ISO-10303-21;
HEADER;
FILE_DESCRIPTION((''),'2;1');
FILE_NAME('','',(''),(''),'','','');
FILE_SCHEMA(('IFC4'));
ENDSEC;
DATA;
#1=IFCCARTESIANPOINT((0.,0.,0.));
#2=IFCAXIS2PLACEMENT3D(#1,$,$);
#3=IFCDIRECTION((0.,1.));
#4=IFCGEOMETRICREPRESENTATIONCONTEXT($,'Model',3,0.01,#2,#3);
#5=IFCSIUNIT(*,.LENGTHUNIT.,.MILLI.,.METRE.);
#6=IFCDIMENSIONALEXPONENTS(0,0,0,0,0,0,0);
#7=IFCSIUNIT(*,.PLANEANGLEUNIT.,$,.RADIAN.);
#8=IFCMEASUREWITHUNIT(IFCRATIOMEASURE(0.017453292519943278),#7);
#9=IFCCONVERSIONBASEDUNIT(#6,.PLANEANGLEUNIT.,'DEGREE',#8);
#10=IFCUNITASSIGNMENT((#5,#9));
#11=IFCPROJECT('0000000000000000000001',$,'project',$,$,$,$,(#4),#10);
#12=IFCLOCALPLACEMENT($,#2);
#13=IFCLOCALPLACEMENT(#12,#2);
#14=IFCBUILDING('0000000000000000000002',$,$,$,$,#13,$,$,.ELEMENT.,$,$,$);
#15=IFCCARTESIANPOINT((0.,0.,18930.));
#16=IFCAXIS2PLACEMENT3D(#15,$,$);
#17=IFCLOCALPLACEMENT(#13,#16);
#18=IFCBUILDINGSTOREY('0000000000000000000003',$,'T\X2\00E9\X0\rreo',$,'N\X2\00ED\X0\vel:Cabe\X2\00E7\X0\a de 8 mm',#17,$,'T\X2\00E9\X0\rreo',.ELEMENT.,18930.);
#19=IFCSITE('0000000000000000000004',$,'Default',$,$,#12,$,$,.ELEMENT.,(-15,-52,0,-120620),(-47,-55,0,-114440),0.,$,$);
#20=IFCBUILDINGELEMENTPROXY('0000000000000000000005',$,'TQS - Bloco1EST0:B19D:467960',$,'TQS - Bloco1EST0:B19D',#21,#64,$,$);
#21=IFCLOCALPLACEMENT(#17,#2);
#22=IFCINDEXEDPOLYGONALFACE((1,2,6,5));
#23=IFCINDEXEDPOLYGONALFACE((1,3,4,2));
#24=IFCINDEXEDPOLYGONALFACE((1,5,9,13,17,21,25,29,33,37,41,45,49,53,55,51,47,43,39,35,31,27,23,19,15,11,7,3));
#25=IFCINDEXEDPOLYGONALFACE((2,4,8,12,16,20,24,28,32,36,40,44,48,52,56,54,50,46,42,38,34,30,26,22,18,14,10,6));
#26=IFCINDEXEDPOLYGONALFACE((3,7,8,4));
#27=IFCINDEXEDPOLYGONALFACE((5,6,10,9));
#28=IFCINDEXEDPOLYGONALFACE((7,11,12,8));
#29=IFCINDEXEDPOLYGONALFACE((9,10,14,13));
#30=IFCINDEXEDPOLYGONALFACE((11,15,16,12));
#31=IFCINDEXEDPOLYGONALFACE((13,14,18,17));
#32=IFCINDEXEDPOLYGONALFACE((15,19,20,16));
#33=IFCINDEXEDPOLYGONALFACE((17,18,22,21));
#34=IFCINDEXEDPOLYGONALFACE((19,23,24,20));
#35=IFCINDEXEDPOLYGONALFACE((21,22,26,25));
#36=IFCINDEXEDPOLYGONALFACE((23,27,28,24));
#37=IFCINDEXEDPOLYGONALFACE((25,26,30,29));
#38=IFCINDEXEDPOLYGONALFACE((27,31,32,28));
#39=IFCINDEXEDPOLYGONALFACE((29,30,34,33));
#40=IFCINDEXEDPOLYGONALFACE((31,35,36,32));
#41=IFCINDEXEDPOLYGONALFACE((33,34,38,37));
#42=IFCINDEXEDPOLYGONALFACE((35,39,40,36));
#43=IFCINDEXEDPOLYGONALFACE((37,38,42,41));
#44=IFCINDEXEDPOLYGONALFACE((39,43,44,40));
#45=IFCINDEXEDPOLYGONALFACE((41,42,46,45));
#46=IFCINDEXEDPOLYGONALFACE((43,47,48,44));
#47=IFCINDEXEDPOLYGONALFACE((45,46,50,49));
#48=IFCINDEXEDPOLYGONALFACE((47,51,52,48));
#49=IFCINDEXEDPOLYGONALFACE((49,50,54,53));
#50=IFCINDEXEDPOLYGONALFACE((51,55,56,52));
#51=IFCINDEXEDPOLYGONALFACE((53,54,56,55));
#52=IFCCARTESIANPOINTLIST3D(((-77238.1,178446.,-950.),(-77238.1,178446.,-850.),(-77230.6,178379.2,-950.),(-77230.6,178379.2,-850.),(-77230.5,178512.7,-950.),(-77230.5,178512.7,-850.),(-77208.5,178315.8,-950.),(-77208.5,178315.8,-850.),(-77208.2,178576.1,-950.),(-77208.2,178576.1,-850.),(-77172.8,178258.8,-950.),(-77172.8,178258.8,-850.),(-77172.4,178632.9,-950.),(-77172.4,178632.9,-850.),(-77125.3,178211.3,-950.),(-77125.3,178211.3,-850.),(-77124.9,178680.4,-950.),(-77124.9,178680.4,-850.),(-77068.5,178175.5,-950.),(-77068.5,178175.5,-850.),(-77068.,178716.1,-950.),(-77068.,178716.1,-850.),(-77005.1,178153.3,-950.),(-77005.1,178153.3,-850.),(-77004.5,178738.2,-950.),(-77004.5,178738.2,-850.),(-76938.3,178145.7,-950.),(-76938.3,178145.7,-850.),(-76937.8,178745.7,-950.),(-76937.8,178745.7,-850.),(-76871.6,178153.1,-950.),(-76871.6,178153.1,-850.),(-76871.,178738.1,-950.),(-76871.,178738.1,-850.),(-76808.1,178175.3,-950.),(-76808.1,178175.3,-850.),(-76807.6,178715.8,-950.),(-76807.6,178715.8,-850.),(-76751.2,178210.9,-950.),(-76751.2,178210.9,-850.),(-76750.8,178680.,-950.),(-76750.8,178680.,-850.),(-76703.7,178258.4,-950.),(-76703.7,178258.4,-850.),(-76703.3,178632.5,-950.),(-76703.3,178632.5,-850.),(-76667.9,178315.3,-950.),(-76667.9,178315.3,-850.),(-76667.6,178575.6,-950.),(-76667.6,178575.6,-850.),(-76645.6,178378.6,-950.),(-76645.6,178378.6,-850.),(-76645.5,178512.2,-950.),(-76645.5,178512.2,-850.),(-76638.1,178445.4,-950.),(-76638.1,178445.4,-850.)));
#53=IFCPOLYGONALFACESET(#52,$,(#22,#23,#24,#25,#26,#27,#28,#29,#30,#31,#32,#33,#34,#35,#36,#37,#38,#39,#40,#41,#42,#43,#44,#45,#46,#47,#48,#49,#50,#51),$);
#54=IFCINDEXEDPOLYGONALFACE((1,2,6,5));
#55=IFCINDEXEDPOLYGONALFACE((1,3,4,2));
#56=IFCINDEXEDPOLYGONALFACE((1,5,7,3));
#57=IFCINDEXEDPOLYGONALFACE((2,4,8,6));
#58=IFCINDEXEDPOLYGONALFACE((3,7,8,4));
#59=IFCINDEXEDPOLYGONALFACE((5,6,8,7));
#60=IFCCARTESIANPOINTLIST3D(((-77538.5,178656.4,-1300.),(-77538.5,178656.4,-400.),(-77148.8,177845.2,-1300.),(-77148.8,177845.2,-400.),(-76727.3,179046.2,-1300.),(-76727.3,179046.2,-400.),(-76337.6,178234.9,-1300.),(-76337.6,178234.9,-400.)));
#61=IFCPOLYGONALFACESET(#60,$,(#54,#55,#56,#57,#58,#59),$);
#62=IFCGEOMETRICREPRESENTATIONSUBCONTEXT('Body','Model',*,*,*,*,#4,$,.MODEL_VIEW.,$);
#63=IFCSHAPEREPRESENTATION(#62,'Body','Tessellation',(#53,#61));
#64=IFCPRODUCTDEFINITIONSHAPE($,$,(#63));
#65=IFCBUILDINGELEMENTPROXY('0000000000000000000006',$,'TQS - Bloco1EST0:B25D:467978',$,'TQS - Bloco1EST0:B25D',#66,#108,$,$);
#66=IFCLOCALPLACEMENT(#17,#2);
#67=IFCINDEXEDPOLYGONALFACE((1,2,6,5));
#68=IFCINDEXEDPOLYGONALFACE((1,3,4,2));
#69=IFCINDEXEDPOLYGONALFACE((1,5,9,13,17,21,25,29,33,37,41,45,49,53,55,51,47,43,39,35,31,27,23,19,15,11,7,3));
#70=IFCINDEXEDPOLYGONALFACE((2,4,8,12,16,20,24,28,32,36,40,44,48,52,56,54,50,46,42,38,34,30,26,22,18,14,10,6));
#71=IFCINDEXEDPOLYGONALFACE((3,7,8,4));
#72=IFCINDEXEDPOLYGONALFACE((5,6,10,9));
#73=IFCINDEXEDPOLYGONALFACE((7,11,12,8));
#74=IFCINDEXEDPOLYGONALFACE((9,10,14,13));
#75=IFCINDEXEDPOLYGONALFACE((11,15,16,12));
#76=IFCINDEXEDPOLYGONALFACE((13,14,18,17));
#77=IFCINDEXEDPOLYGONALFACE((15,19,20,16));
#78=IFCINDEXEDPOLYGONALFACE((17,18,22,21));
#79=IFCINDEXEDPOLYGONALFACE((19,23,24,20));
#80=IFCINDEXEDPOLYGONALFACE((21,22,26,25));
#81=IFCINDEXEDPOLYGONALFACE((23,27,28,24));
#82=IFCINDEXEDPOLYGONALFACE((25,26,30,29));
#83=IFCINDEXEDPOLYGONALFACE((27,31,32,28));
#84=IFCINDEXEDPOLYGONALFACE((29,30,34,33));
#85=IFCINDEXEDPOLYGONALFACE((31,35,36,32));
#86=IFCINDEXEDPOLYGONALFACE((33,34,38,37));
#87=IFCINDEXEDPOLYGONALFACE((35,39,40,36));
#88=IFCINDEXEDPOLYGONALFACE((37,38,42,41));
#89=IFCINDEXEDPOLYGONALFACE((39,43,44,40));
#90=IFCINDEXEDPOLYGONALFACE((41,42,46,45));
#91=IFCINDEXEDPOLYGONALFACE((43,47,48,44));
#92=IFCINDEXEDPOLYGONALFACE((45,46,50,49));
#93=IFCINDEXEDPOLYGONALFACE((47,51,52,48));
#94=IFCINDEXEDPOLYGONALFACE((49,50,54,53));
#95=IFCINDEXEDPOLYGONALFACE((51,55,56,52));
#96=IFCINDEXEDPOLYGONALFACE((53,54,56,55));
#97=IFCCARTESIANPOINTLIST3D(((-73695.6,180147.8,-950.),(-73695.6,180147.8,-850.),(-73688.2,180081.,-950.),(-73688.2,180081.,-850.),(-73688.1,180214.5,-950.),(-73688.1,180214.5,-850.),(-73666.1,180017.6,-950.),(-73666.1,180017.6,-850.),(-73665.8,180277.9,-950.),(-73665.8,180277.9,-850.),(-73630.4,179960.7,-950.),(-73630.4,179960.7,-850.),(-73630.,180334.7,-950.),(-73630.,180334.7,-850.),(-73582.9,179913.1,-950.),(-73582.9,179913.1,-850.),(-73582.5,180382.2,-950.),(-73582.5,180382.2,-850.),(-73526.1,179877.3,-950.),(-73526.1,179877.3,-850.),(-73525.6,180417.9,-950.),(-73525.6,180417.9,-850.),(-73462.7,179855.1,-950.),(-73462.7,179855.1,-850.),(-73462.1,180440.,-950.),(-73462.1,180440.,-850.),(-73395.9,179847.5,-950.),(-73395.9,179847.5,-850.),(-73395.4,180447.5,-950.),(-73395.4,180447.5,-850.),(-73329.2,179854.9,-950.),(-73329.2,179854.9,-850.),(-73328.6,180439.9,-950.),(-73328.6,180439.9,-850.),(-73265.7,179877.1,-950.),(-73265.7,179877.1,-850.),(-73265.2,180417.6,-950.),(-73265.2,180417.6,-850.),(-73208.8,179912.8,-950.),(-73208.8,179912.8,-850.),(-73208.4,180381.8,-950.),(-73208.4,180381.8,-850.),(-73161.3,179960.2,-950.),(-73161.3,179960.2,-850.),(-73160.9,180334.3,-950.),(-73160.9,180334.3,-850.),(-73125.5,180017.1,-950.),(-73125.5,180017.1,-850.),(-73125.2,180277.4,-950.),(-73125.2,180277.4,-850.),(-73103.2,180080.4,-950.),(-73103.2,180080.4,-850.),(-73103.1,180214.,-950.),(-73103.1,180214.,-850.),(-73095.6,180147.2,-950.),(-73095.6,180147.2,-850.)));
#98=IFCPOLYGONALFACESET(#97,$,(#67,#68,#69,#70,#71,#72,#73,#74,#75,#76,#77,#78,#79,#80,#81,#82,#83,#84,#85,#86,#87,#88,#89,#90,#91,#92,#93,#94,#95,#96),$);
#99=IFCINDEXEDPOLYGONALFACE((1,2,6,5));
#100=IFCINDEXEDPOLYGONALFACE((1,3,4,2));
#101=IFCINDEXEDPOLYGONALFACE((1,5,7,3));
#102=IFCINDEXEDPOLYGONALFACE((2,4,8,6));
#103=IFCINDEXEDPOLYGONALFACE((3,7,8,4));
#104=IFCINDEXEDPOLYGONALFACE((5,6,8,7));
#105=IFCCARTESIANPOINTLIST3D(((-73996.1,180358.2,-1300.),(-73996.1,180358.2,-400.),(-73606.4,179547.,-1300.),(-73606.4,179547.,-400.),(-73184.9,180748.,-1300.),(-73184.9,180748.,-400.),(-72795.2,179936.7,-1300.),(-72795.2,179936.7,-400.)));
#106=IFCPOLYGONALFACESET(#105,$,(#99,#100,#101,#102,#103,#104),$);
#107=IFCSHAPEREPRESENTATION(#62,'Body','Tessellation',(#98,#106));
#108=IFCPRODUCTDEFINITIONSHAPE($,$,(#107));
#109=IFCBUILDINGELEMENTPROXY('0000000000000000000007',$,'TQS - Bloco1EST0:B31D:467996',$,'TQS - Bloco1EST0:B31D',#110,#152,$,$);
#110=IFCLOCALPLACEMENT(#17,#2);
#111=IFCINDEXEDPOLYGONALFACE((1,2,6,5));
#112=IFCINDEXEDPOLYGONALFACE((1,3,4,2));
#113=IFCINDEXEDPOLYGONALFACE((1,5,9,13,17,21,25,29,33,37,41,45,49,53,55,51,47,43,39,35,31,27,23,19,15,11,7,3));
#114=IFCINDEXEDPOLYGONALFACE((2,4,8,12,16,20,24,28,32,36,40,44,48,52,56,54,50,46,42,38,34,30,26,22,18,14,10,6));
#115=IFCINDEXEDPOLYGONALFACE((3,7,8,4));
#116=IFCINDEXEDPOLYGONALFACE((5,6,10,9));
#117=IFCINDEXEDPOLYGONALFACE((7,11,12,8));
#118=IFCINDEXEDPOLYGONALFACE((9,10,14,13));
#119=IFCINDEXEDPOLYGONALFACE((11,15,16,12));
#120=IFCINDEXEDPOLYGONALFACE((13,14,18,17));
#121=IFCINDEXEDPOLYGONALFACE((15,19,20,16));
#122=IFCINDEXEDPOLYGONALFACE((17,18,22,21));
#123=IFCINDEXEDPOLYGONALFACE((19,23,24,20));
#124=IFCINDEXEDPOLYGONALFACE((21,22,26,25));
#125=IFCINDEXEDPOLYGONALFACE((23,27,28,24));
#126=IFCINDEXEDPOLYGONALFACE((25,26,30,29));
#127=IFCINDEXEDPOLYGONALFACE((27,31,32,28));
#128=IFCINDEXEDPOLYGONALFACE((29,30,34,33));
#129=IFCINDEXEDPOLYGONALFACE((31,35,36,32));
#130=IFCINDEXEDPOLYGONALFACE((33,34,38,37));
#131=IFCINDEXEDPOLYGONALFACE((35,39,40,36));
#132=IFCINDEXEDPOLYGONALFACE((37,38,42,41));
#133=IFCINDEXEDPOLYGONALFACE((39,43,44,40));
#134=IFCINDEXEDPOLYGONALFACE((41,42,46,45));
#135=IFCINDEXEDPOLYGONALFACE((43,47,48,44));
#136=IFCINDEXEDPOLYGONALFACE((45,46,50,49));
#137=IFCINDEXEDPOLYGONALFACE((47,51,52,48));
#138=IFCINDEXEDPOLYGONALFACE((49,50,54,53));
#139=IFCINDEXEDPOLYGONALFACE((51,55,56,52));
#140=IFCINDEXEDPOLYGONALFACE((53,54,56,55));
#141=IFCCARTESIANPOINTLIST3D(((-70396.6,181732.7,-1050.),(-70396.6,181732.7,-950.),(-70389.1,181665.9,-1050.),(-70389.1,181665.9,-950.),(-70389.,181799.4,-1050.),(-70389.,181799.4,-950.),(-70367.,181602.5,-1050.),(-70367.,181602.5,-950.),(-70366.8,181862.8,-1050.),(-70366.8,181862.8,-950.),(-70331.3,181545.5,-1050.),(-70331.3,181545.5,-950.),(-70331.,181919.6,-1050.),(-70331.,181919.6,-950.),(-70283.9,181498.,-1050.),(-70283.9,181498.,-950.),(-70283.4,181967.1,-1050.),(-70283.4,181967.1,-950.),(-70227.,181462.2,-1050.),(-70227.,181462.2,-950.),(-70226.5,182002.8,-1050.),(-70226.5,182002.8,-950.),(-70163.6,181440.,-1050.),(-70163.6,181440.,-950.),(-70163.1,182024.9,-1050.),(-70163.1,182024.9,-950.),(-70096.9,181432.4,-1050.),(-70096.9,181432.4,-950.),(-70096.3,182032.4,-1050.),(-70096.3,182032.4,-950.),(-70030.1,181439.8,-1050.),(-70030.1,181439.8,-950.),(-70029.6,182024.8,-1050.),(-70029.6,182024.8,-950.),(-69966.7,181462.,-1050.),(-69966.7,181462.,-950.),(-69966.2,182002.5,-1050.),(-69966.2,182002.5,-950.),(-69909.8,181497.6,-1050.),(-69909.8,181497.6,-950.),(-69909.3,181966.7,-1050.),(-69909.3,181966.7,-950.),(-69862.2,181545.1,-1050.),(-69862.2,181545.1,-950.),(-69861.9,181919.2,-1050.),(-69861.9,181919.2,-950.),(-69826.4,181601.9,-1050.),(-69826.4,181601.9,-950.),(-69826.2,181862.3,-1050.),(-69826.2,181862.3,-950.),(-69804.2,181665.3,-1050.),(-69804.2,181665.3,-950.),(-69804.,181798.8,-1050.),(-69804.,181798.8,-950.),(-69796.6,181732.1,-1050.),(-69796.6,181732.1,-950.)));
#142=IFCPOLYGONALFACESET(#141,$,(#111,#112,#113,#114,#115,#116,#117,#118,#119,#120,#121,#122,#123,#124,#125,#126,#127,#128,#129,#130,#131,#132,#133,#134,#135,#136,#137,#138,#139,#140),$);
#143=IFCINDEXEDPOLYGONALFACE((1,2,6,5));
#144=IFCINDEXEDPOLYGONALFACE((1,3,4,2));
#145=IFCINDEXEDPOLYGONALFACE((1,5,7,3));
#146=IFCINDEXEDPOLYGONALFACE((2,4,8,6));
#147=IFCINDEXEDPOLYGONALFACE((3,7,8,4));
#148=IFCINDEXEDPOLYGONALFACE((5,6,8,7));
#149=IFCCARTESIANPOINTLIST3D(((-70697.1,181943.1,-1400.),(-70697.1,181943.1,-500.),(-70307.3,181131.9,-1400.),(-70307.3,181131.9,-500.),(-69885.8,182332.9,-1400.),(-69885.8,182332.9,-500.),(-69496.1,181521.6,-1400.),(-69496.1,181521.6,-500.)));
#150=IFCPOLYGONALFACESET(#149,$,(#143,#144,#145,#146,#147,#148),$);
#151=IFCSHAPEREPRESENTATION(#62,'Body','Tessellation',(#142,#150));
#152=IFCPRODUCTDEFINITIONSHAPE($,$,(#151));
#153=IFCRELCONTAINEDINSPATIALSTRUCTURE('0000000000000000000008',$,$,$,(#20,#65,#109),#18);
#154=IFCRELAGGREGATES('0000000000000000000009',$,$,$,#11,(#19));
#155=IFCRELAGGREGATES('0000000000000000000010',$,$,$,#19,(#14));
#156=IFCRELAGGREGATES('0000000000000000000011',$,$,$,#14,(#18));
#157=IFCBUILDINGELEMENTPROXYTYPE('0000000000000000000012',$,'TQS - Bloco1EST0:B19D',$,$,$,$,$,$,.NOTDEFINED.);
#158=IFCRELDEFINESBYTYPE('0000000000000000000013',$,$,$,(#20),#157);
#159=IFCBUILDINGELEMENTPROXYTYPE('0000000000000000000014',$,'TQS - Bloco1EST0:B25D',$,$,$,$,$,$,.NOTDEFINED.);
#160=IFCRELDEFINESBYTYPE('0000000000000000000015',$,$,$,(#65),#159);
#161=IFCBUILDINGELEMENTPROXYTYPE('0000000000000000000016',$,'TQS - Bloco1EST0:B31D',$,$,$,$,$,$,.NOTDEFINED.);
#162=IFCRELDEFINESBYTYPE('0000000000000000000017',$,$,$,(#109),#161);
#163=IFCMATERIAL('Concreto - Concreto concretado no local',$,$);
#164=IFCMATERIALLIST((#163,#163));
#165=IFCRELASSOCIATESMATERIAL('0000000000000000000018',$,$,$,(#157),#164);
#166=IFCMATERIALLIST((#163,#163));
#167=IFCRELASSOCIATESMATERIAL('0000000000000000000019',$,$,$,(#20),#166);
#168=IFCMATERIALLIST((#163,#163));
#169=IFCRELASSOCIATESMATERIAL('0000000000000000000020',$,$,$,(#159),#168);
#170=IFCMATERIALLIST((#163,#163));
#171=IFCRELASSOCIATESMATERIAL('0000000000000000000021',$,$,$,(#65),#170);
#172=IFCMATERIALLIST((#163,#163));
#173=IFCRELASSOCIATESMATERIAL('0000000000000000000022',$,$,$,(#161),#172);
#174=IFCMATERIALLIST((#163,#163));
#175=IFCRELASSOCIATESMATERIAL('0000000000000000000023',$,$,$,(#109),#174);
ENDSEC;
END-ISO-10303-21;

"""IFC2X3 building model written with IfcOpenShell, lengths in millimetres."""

from ifc_helpers import new_model, entity, si_unit, converted_unit, direction, frame, frame_2d, origin, origin_2d_with_axis, place, context, subcontext, project, spatial, rectangle, circle, extrude, source, transform, mapped, material, material_list, type_object, type_shapes, element, save


model = new_model("IFC2X3")

# Units and contexts
model_context = context("Model", 3, precision=0.01, world=origin(), true_north=direction((0.0, 1.0)))
body_context = subcontext(model_context, "Body", "Model", "MODEL_VIEW")
ifc_project = project(units=[si_unit("LENGTHUNIT", "METRE", prefix="MILLI"), converted_unit("PLANEANGLEUNIT", "DEGREE", entity("IfcRatioMeasure", 0.017453292519943278), si_unit("PLANEANGLEUNIT", "RADIAN"), dimensions=[0, 0, 0, 0, 0, 0, 0])], contexts=[model_context])

# Site, building, storey
site_placement = place(None, origin())
site = spatial("IfcSite", under=ifc_project, at=site_placement, Name="Default", CompositionType="ELEMENT", RefLatitude=(-15, -52, 0, -120620), RefLongitude=(-47, -55, 0, -114440), RefElevation=0.0)
building_placement = place(site_placement, origin())
building = spatial("IfcBuilding", under=site, at=building_placement, CompositionType="ELEMENT")
storey_placement = place(building_placement, frame((0.0, 0.0, 18930.0)))
storey = spatial("IfcBuildingStorey", under=building, at=storey_placement, Name="Térreo", ObjectType="Nível:Cabeça de 8 mm", LongName="Térreo", CompositionType="ELEMENT", Elevation=18930.0)

# Building element proxies
ifc_material_1 = material(Name="Concreto - Concreto concretado no local")
ifc_material_list_1 = material_list([ifc_material_1, ifc_material_1])
ifc_material_list_2 = material_list([ifc_material_1, ifc_material_1])
building_element_proxy_type_1 = type_object("IfcBuildingElementProxyType", Name="TQS - Bloco1EST0:B19D", PredefinedType="NOTDEFINED", material=ifc_material_list_2)
shared_shape_1 = source(origin(), body_context, "Body", "SweptSolid", [
    extrude(circle(Radius=300.0, at=frame_2d((0.0, 0.0), x_axis=(1.0, 0.0))), frame((0.0, 0.0, -550.0)), (0.0, 0.0, 1.0), 100.0),
    extrude(rectangle(XDim=900.0, YDim=900.0, at=origin_2d_with_axis()), frame((0.0, 0.0, -900.0), z_axis=(0.0, 0.0, 1.0), x_axis=(-1.0, 0.0, 0.0)), (0.0, 0.0, 1.0), 900.0),
])
type_shapes(building_element_proxy_type_1, [shared_shape_1])
proxy_1_placement = place(storey_placement, frame((-76938.1, 178445.7, -400.0), z_axis=(0.0, 0.0, 1.0), x_axis=(-0.43303, 0.90138, 0.0)))
element("IfcBuildingElementProxy", 1, at=proxy_1_placement, inside=storey, type_object=building_element_proxy_type_1, material=ifc_material_list_1, Name="TQS - Bloco1EST0:B19D:467960", ObjectType="TQS - Bloco1EST0:B19D", context=body_context, shape_type="MappedRepresentation", body=[
    mapped(shared_shape_1, transform((0.0, 0.0, 0.0), scale=1.0)),
])
ifc_material_list_3 = material_list([ifc_material_1, ifc_material_1])
ifc_material_list_4 = material_list([ifc_material_1, ifc_material_1])
building_element_proxy_type_2 = type_object("IfcBuildingElementProxyType", Name="TQS - Bloco1EST0:B25D", PredefinedType="NOTDEFINED", material=ifc_material_list_4)
shared_shape_2 = source(origin(), body_context, "Body", "SweptSolid", [
    extrude(circle(Radius=300.0, at=frame_2d((0.0, 0.0), x_axis=(1.0, 0.0))), frame((0.0, 0.0, -550.0)), (0.0, 0.0, 1.0), 100.0),
    extrude(rectangle(XDim=900.0, YDim=900.0, at=origin_2d_with_axis()), frame((0.0, 0.0, -900.0), z_axis=(0.0, 0.0, 1.0), x_axis=(-1.0, 0.0, 0.0)), (0.0, 0.0, 1.0), 900.0),
])
type_shapes(building_element_proxy_type_2, [shared_shape_2])
proxy_2_placement = place(storey_placement, frame((-73395.6, 180147.5, -400.0), z_axis=(0.0, 0.0, 1.0), x_axis=(-0.43303, 0.90138, 0.0)))
element("IfcBuildingElementProxy", 2, at=proxy_2_placement, inside=storey, type_object=building_element_proxy_type_2, material=ifc_material_list_3, Name="TQS - Bloco1EST0:B25D:467978", ObjectType="TQS - Bloco1EST0:B25D", context=body_context, shape_type="MappedRepresentation", body=[
    mapped(shared_shape_2, transform((0.0, 0.0, 0.0), scale=1.0)),
])
ifc_material_list_5 = material_list([ifc_material_1, ifc_material_1])
ifc_material_list_6 = material_list([ifc_material_1, ifc_material_1])
building_element_proxy_type_3 = type_object("IfcBuildingElementProxyType", Name="TQS - Bloco1EST0:B31D", PredefinedType="NOTDEFINED", material=ifc_material_list_6)
shared_shape_3 = source(origin(), body_context, "Body", "SweptSolid", [
    extrude(circle(Radius=300.0, at=frame_2d((0.0, 0.0), x_axis=(1.0, 0.0))), frame((0.0, 0.0, -550.0)), (0.0, 0.0, 1.0), 100.0),
    extrude(rectangle(XDim=900.0, YDim=900.0, at=origin_2d_with_axis()), frame((0.0, 0.0, -900.0), z_axis=(0.0, 0.0, 1.0), x_axis=(-1.0, 0.0, 0.0)), (0.0, 0.0, 1.0), 900.0),
])
type_shapes(building_element_proxy_type_3, [shared_shape_3])
proxy_3_placement = place(storey_placement, frame((-70096.6, 181732.4, -500.0), z_axis=(0.0, 0.0, 1.0), x_axis=(-0.43303, 0.90138, 0.0)))
element("IfcBuildingElementProxy", 3, at=proxy_3_placement, inside=storey, type_object=building_element_proxy_type_3, material=ifc_material_list_5, Name="TQS - Bloco1EST0:B31D:467996", ObjectType="TQS - Bloco1EST0:B31D", context=body_context, shape_type="MappedRepresentation", body=[
    mapped(shared_shape_3, transform((0.0, 0.0, 0.0), scale=1.0)),
])

save(model, "model.ifc")
